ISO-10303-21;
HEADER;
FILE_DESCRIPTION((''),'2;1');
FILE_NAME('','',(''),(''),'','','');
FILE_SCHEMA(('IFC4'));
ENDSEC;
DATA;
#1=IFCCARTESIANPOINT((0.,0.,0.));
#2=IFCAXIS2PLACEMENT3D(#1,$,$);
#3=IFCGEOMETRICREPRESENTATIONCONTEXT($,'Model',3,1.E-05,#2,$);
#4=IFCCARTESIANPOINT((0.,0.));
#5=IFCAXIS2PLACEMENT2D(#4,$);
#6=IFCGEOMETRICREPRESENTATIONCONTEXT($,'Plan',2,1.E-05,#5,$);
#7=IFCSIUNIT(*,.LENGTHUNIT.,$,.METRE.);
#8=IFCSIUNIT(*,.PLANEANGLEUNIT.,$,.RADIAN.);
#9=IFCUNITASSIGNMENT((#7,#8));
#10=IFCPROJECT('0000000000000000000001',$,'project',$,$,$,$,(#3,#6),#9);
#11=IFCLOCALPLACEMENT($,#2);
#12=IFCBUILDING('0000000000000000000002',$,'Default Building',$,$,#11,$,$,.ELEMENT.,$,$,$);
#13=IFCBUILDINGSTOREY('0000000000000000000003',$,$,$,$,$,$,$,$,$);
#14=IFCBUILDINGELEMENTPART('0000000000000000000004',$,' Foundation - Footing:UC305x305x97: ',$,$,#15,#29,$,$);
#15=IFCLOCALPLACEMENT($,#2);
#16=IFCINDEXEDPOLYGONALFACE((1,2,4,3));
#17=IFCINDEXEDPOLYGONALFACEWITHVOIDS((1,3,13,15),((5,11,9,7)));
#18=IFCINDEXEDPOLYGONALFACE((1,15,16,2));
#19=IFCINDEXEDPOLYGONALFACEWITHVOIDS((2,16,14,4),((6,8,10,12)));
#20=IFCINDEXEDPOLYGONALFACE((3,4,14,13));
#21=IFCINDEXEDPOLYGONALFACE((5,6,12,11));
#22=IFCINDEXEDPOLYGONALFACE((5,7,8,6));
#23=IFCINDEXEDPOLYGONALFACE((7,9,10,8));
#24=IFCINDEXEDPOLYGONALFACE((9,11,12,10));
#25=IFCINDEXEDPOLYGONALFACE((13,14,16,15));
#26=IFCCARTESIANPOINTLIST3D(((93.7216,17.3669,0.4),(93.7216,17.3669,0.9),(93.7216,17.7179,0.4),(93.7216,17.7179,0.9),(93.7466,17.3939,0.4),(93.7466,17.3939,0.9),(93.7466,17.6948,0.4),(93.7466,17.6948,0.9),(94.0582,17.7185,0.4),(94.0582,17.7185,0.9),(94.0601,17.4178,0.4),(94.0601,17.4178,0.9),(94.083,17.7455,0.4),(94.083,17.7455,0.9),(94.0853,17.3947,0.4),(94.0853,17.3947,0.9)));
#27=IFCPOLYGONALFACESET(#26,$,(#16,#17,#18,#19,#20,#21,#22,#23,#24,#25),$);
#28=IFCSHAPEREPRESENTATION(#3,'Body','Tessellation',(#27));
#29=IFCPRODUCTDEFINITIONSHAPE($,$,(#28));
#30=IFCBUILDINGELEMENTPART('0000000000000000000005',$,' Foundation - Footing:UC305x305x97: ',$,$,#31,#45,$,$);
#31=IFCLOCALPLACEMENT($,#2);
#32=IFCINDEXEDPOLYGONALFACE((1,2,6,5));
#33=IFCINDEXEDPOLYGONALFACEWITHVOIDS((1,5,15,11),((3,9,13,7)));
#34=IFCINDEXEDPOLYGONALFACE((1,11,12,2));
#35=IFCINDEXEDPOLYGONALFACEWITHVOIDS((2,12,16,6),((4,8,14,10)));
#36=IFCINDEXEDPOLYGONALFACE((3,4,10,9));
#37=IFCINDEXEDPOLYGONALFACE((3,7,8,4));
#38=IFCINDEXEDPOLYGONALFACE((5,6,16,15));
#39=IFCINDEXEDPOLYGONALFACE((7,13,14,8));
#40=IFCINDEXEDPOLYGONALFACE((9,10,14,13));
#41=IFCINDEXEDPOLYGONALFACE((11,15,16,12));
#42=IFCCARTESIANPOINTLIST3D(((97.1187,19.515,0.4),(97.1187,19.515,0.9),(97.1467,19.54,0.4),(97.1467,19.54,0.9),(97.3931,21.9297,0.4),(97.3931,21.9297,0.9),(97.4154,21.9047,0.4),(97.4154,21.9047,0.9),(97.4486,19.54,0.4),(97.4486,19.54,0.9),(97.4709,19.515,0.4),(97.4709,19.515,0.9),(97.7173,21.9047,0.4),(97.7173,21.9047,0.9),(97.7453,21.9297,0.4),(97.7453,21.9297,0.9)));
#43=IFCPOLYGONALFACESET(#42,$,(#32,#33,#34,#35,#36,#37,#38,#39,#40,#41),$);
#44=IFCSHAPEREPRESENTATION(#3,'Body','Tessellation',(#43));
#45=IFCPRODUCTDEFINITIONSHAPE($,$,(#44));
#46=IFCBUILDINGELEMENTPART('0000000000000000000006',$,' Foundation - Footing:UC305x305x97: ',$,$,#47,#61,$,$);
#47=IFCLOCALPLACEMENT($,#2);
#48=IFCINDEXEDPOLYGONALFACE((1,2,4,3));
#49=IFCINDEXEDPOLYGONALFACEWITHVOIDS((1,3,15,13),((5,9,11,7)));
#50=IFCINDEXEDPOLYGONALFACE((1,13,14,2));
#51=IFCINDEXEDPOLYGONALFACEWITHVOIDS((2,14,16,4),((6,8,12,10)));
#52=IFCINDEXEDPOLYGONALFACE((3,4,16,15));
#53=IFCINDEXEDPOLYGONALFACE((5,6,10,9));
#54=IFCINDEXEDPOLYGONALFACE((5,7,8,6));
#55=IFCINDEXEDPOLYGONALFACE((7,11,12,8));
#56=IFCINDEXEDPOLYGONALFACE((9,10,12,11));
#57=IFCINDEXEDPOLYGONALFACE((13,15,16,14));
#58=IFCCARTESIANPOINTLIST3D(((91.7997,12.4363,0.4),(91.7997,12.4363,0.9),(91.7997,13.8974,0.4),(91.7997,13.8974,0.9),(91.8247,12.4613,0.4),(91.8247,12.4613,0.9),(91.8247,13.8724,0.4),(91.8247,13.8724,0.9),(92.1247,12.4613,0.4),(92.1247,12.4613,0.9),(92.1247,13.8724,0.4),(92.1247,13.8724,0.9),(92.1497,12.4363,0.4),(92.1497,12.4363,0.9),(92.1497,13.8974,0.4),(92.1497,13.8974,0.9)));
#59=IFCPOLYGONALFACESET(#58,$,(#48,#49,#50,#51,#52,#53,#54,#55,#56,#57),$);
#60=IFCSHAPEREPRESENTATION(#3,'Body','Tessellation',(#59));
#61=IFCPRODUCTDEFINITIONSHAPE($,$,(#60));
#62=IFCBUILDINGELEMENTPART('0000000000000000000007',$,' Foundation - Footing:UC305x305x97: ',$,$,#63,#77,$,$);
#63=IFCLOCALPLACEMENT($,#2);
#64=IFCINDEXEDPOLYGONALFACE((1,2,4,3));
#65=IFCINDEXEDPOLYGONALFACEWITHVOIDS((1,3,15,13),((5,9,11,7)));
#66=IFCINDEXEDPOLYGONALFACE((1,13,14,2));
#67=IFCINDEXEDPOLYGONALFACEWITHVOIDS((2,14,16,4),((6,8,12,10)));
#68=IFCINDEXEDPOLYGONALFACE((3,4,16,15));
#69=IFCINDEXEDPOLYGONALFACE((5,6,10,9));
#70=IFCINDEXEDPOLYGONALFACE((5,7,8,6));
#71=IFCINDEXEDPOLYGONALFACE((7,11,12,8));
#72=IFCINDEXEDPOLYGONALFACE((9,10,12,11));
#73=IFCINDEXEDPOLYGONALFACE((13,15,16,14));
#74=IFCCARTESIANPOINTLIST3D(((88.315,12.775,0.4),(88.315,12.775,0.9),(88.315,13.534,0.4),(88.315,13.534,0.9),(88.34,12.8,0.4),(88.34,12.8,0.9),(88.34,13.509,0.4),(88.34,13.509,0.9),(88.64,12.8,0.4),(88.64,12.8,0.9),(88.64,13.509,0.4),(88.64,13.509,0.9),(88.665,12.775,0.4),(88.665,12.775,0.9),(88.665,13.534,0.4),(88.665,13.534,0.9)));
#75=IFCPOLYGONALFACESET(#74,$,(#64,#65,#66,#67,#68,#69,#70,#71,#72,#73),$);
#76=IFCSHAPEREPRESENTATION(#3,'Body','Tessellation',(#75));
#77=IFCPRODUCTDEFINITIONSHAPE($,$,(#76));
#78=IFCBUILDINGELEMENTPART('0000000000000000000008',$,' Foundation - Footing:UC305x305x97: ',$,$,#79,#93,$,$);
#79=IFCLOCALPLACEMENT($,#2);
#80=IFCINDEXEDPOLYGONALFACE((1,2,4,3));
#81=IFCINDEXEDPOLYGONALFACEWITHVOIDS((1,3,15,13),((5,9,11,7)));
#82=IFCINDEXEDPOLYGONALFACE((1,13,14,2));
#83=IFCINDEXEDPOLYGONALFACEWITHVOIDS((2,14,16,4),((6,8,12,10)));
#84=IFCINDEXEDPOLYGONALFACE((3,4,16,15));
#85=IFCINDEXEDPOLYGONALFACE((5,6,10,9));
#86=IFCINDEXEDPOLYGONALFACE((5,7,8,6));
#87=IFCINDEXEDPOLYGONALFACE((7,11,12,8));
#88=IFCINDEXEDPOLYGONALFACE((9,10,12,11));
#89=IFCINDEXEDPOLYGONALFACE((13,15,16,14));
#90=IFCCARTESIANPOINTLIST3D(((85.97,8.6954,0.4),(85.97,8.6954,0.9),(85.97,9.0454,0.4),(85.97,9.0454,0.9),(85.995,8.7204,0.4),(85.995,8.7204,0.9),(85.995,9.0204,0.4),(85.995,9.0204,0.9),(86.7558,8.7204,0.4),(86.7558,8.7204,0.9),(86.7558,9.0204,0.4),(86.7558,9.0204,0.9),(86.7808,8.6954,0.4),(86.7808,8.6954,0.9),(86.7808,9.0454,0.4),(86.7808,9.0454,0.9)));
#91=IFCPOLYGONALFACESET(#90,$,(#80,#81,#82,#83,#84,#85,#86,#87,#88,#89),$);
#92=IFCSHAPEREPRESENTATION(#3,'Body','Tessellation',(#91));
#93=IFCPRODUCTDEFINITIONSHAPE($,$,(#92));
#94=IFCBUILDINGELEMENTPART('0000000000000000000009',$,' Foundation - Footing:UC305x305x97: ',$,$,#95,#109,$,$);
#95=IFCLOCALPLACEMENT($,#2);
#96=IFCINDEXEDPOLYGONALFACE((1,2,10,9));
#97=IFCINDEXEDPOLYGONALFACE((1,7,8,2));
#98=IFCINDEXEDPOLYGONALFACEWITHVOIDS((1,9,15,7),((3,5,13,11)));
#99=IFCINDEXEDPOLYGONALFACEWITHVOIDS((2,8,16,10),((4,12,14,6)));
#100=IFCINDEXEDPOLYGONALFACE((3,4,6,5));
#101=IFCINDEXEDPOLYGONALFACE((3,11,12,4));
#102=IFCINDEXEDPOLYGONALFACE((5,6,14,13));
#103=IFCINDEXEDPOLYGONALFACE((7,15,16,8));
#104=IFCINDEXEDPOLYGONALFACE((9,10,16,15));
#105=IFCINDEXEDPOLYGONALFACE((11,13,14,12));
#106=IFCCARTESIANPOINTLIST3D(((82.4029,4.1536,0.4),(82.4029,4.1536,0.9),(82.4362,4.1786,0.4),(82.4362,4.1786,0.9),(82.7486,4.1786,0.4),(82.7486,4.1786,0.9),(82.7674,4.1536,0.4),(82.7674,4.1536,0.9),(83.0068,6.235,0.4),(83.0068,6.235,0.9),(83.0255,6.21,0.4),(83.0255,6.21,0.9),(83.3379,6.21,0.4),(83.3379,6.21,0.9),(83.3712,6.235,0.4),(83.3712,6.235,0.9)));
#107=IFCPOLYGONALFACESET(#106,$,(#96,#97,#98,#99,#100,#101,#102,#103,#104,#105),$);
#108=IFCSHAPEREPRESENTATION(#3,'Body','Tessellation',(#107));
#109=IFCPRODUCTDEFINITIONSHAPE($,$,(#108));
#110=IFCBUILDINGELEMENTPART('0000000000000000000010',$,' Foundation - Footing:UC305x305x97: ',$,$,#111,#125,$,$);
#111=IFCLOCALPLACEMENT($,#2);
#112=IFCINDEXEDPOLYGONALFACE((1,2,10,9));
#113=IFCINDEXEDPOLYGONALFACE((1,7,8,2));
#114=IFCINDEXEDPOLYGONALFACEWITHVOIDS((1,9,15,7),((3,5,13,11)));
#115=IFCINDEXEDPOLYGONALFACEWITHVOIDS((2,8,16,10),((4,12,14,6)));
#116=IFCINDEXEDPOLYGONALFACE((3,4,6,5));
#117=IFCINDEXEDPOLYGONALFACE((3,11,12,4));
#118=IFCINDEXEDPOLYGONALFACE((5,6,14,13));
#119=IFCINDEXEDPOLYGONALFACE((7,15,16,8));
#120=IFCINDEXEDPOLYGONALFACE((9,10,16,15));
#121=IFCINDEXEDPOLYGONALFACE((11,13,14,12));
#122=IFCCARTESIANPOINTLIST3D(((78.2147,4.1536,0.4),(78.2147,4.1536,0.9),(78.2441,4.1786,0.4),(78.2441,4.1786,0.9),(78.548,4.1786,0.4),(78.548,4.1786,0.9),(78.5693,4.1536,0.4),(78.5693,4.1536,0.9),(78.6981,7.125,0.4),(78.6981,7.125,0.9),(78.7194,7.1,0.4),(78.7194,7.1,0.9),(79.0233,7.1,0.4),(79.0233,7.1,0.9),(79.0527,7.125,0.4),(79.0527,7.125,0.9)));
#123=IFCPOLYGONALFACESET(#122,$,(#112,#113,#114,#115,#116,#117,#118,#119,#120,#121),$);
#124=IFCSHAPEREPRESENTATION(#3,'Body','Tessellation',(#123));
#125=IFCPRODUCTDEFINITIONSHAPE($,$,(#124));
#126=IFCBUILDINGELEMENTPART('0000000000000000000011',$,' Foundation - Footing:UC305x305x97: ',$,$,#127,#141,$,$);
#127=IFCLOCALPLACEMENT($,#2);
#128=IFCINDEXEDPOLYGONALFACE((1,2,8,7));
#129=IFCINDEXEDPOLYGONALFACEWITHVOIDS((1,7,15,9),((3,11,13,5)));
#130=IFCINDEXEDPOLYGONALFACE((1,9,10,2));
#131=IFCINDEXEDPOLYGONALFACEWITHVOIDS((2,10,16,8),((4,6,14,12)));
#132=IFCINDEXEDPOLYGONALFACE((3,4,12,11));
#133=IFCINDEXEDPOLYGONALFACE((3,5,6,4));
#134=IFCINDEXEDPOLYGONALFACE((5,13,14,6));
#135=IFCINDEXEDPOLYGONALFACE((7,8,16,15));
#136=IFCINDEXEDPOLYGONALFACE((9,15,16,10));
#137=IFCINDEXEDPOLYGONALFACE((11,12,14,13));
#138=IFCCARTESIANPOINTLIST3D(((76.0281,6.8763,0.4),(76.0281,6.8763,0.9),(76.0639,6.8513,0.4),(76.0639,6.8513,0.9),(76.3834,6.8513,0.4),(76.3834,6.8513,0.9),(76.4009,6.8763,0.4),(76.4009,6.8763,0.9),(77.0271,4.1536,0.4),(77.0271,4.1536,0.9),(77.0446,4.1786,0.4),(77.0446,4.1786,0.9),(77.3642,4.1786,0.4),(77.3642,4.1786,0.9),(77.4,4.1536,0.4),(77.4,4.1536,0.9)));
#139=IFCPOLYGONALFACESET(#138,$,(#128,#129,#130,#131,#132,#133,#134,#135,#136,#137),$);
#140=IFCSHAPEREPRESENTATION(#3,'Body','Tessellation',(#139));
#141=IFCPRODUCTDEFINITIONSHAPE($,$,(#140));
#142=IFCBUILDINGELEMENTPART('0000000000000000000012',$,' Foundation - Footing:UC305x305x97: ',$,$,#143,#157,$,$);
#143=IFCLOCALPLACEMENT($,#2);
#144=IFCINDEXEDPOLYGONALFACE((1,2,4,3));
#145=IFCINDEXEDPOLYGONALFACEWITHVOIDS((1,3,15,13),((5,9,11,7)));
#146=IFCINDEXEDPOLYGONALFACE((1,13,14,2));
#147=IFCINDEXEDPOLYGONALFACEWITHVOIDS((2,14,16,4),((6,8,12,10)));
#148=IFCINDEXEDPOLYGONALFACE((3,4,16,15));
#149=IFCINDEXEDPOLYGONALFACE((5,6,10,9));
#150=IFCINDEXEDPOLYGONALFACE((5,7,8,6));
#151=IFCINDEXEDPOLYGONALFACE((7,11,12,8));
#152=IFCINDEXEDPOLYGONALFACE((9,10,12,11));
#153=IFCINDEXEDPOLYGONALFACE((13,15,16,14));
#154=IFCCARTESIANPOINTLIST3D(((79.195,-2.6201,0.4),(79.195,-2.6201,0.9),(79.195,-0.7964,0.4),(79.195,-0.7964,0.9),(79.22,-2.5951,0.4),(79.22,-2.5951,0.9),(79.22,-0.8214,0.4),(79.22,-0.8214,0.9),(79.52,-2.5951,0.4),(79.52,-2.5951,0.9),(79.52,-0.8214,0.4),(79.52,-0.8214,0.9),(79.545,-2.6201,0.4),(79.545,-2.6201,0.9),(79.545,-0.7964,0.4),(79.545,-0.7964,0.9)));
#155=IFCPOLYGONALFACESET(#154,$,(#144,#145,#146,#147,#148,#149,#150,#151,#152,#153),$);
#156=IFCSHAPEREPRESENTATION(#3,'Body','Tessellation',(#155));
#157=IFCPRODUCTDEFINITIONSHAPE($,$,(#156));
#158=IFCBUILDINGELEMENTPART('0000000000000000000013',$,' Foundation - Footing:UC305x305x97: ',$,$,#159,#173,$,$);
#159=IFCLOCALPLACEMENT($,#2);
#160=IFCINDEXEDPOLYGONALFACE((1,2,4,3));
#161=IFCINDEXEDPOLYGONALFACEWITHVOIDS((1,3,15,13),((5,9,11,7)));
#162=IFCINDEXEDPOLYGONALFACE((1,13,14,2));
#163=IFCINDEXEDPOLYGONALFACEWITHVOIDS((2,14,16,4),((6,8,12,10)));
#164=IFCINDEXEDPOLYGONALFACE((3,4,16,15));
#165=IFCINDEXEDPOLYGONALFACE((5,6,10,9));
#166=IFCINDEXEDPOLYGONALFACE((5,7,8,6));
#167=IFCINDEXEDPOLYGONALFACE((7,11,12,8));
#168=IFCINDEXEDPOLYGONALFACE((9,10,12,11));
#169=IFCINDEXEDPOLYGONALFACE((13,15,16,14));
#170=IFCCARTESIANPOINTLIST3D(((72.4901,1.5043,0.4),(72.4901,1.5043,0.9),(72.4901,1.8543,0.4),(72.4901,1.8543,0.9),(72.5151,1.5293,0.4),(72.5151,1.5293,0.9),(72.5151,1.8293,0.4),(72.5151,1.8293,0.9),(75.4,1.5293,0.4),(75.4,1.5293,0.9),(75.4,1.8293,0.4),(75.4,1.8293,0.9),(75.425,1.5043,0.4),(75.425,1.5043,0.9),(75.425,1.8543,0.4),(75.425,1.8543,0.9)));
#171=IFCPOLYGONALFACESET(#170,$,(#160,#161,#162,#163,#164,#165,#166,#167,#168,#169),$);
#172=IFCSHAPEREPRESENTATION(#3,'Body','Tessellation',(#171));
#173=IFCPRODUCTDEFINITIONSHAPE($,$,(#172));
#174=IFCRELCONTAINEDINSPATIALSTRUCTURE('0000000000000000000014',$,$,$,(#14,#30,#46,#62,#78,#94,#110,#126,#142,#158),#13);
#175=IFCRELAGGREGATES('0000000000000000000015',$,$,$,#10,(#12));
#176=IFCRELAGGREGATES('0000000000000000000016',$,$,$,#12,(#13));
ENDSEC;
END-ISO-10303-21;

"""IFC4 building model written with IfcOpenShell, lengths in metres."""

from ifc_helpers import new_model, si_unit, origin, origin_2d, place, context, project, spatial, polyline, outline, extrude, element, save


model = new_model("IFC4")

# Units and contexts
model_context = context("Model", 3, precision=1e-05, world=origin())
plan_context = context("Plan", 2, precision=1e-05, world=origin_2d())
ifc_project = project(units=[si_unit("LENGTHUNIT", "METRE"), si_unit("PLANEANGLEUNIT", "RADIAN")], contexts=[model_context, plan_context])

# Building, storey
building_placement = place(None, origin())
building = spatial("IfcBuilding", under=ifc_project, at=building_placement, Name="Default Building", CompositionType="ELEMENT")
storey = spatial("IfcBuildingStorey", under=building)

# Building element parts, openings
building_element_part_1 = element("IfcBuildingElementPart", 1, inside=storey, Name=" Foundation - Footing:UC305x305x97: ", context=model_context, shape_type="SweptSolid", body=[
    extrude(outline(polyline([(94.0853, 17.3947, 0.4), (93.7216, 17.3669, 0.4), (93.7216, 17.7179, 0.4), (94.083, 17.7455, 0.4), (94.0853, 17.3947, 0.4)])), None, (0.0, 0.0, 1.0), 0.5),
])
element("IfcOpeningElement", 2, inside=storey, cuts=building_element_part_1, context=model_context, shape_type="SweptSolid", body=[
    extrude(outline(polyline([(94.0601, 17.4178, 0.4), (93.7466, 17.3939, 0.4), (93.7466, 17.6948, 0.4), (94.0582, 17.7185, 0.4), (94.0601, 17.4178, 0.4)])), None, (0.0, 0.0, 1.0), 0.5),
])
building_element_part_2 = element("IfcBuildingElementPart", 3, inside=storey, Name=" Foundation - Footing:UC305x305x97: ", context=model_context, shape_type="SweptSolid", body=[
    extrude(outline(polyline([(97.4709, 19.515, 0.4), (97.1187, 19.515, 0.4), (97.3931, 21.9297, 0.4), (97.7453, 21.9297, 0.4), (97.4709, 19.515, 0.4)])), None, (0.0, 0.0, 1.0), 0.5),
])
element("IfcOpeningElement", 4, inside=storey, cuts=building_element_part_2, context=model_context, shape_type="SweptSolid", body=[
    extrude(outline(polyline([(97.4486, 19.54, 0.4), (97.1467, 19.54, 0.4), (97.4154, 21.9047, 0.4), (97.7173, 21.9047, 0.4), (97.4486, 19.54, 0.4)])), None, (0.0, 0.0, 1.0), 0.5),
])
building_element_part_3 = element("IfcBuildingElementPart", 5, inside=storey, Name=" Foundation - Footing:UC305x305x97: ", context=model_context, shape_type="SweptSolid", body=[
    extrude(outline(polyline([(92.1497, 12.4363, 0.4), (91.7997, 12.4363, 0.4), (91.7997, 13.8974, 0.4), (92.1497, 13.8974, 0.4), (92.1497, 12.4363, 0.4)])), None, (0.0, 0.0, 1.0), 0.5),
])
element("IfcOpeningElement", 6, inside=storey, cuts=building_element_part_3, context=model_context, shape_type="SweptSolid", body=[
    extrude(outline(polyline([(92.1247, 12.4613, 0.4), (91.8247, 12.4613, 0.4), (91.8247, 13.8724, 0.4), (92.1247, 13.8724, 0.4), (92.1247, 12.4613, 0.4)])), None, (0.0, 0.0, 1.0), 0.5),
])
building_element_part_4 = element("IfcBuildingElementPart", 7, inside=storey, Name=" Foundation - Footing:UC305x305x97: ", context=model_context, shape_type="SweptSolid", body=[
    extrude(outline(polyline([(88.665, 12.775, 0.4), (88.315, 12.775, 0.4), (88.315, 13.534, 0.4), (88.665, 13.534, 0.4), (88.665, 12.775, 0.4)])), None, (0.0, 0.0, 1.0), 0.5),
])
element("IfcOpeningElement", 8, inside=storey, cuts=building_element_part_4, context=model_context, shape_type="SweptSolid", body=[
    extrude(outline(polyline([(88.64, 12.8, 0.4), (88.34, 12.8, 0.4), (88.34, 13.509, 0.4), (88.64, 13.509, 0.4), (88.64, 12.8, 0.4)])), None, (0.0, 0.0, 1.0), 0.5),
])
building_element_part_5 = element("IfcBuildingElementPart", 9, inside=storey, Name=" Foundation - Footing:UC305x305x97: ", context=model_context, shape_type="SweptSolid", body=[
    extrude(outline(polyline([(86.7808, 8.6954, 0.4), (85.97, 8.6954, 0.4), (85.97, 9.0454, 0.4), (86.7808, 9.0454, 0.4), (86.7808, 8.6954, 0.4)])), None, (0.0, 0.0, 1.0), 0.5),
])
element("IfcOpeningElement", 10, inside=storey, cuts=building_element_part_5, context=model_context, shape_type="SweptSolid", body=[
    extrude(outline(polyline([(86.7558, 8.7204, 0.4), (85.995, 8.7204, 0.4), (85.995, 9.0204, 0.4), (86.7558, 9.0204, 0.4), (86.7558, 8.7204, 0.4)])), None, (0.0, 0.0, 1.0), 0.5),
])
building_element_part_6 = element("IfcBuildingElementPart", 11, inside=storey, Name=" Foundation - Footing:UC305x305x97: ", context=model_context, shape_type="SweptSolid", body=[
    extrude(outline(polyline([(82.7674, 4.1536, 0.4), (82.4029, 4.1536, 0.4), (83.0068, 6.235, 0.4), (83.3712, 6.235, 0.4), (82.7674, 4.1536, 0.4)])), None, (0.0, 0.0, 1.0), 0.5),
])
element("IfcOpeningElement", 12, inside=storey, cuts=building_element_part_6, context=model_context, shape_type="SweptSolid", body=[
    extrude(outline(polyline([(82.7486, 4.1786, 0.4), (82.4362, 4.1786, 0.4), (83.0255, 6.21, 0.4), (83.3379, 6.21, 0.4), (82.7486, 4.1786, 0.4)])), None, (0.0, 0.0, 1.0), 0.5),
])
building_element_part_7 = element("IfcBuildingElementPart", 13, inside=storey, Name=" Foundation - Footing:UC305x305x97: ", context=model_context, shape_type="SweptSolid", body=[
    extrude(outline(polyline([(78.5693, 4.1536, 0.4), (78.2147, 4.1536, 0.4), (78.6981, 7.125, 0.4), (79.0527, 7.125, 0.4), (78.5693, 4.1536, 0.4)])), None, (0.0, 0.0, 1.0), 0.5),
])
element("IfcOpeningElement", 14, inside=storey, cuts=building_element_part_7, context=model_context, shape_type="SweptSolid", body=[
    extrude(outline(polyline([(78.548, 4.1786, 0.4), (78.2441, 4.1786, 0.4), (78.7194, 7.1, 0.4), (79.0233, 7.1, 0.4), (78.548, 4.1786, 0.4)])), None, (0.0, 0.0, 1.0), 0.5),
])
building_element_part_8 = element("IfcBuildingElementPart", 15, inside=storey, Name=" Foundation - Footing:UC305x305x97: ", context=model_context, shape_type="SweptSolid", body=[
    extrude(outline(polyline([(77.4, 4.1536, 0.4), (77.0271, 4.1536, 0.4), (76.0281, 6.8763, 0.4), (76.4009, 6.8763, 0.4), (77.4, 4.1536, 0.4)])), None, (0.0, 0.0, 1.0), 0.5),
])
element("IfcOpeningElement", 16, inside=storey, cuts=building_element_part_8, context=model_context, shape_type="SweptSolid", body=[
    extrude(outline(polyline([(77.3642, 4.1786, 0.4), (77.0446, 4.1786, 0.4), (76.0639, 6.8513, 0.4), (76.3834, 6.8513, 0.4), (77.3642, 4.1786, 0.4)])), None, (0.0, 0.0, 1.0), 0.5),
])
building_element_part_9 = element("IfcBuildingElementPart", 17, inside=storey, Name=" Foundation - Footing:UC305x305x97: ", context=model_context, shape_type="SweptSolid", body=[
    extrude(outline(polyline([(79.545, -2.6201, 0.4), (79.195, -2.6201, 0.4), (79.195, -0.7964, 0.4), (79.545, -0.7964, 0.4), (79.545, -2.6201, 0.4)])), None, (0.0, 0.0, 1.0), 0.5),
])
element("IfcOpeningElement", 18, inside=storey, cuts=building_element_part_9, context=model_context, shape_type="SweptSolid", body=[
    extrude(outline(polyline([(79.52, -2.5951, 0.4), (79.22, -2.5951, 0.4), (79.22, -0.8214, 0.4), (79.52, -0.8214, 0.4), (79.52, -2.5951, 0.4)])), None, (0.0, 0.0, 1.0), 0.5),
])
building_element_part_10 = element("IfcBuildingElementPart", 19, inside=storey, Name=" Foundation - Footing:UC305x305x97: ", context=model_context, shape_type="SweptSolid", body=[
    extrude(outline(polyline([(75.425, 1.5043, 0.4), (75.425, 1.8543, 0.4), (72.4901, 1.8543, 0.4), (72.4901, 1.5043, 0.4), (75.425, 1.5043, 0.4)])), None, (0.0, 0.0, 1.0), 0.5),
])
element("IfcOpeningElement", 20, inside=storey, cuts=building_element_part_10, context=model_context, shape_type="SweptSolid", body=[
    extrude(outline(polyline([(75.4, 1.5293, 0.4), (75.4, 1.8293, 0.4), (72.5151, 1.8293, 0.4), (72.5151, 1.5293, 0.4), (75.4, 1.5293, 0.4)])), None, (0.0, 0.0, 1.0), 0.5),
])

save(model, "model.ifc")
